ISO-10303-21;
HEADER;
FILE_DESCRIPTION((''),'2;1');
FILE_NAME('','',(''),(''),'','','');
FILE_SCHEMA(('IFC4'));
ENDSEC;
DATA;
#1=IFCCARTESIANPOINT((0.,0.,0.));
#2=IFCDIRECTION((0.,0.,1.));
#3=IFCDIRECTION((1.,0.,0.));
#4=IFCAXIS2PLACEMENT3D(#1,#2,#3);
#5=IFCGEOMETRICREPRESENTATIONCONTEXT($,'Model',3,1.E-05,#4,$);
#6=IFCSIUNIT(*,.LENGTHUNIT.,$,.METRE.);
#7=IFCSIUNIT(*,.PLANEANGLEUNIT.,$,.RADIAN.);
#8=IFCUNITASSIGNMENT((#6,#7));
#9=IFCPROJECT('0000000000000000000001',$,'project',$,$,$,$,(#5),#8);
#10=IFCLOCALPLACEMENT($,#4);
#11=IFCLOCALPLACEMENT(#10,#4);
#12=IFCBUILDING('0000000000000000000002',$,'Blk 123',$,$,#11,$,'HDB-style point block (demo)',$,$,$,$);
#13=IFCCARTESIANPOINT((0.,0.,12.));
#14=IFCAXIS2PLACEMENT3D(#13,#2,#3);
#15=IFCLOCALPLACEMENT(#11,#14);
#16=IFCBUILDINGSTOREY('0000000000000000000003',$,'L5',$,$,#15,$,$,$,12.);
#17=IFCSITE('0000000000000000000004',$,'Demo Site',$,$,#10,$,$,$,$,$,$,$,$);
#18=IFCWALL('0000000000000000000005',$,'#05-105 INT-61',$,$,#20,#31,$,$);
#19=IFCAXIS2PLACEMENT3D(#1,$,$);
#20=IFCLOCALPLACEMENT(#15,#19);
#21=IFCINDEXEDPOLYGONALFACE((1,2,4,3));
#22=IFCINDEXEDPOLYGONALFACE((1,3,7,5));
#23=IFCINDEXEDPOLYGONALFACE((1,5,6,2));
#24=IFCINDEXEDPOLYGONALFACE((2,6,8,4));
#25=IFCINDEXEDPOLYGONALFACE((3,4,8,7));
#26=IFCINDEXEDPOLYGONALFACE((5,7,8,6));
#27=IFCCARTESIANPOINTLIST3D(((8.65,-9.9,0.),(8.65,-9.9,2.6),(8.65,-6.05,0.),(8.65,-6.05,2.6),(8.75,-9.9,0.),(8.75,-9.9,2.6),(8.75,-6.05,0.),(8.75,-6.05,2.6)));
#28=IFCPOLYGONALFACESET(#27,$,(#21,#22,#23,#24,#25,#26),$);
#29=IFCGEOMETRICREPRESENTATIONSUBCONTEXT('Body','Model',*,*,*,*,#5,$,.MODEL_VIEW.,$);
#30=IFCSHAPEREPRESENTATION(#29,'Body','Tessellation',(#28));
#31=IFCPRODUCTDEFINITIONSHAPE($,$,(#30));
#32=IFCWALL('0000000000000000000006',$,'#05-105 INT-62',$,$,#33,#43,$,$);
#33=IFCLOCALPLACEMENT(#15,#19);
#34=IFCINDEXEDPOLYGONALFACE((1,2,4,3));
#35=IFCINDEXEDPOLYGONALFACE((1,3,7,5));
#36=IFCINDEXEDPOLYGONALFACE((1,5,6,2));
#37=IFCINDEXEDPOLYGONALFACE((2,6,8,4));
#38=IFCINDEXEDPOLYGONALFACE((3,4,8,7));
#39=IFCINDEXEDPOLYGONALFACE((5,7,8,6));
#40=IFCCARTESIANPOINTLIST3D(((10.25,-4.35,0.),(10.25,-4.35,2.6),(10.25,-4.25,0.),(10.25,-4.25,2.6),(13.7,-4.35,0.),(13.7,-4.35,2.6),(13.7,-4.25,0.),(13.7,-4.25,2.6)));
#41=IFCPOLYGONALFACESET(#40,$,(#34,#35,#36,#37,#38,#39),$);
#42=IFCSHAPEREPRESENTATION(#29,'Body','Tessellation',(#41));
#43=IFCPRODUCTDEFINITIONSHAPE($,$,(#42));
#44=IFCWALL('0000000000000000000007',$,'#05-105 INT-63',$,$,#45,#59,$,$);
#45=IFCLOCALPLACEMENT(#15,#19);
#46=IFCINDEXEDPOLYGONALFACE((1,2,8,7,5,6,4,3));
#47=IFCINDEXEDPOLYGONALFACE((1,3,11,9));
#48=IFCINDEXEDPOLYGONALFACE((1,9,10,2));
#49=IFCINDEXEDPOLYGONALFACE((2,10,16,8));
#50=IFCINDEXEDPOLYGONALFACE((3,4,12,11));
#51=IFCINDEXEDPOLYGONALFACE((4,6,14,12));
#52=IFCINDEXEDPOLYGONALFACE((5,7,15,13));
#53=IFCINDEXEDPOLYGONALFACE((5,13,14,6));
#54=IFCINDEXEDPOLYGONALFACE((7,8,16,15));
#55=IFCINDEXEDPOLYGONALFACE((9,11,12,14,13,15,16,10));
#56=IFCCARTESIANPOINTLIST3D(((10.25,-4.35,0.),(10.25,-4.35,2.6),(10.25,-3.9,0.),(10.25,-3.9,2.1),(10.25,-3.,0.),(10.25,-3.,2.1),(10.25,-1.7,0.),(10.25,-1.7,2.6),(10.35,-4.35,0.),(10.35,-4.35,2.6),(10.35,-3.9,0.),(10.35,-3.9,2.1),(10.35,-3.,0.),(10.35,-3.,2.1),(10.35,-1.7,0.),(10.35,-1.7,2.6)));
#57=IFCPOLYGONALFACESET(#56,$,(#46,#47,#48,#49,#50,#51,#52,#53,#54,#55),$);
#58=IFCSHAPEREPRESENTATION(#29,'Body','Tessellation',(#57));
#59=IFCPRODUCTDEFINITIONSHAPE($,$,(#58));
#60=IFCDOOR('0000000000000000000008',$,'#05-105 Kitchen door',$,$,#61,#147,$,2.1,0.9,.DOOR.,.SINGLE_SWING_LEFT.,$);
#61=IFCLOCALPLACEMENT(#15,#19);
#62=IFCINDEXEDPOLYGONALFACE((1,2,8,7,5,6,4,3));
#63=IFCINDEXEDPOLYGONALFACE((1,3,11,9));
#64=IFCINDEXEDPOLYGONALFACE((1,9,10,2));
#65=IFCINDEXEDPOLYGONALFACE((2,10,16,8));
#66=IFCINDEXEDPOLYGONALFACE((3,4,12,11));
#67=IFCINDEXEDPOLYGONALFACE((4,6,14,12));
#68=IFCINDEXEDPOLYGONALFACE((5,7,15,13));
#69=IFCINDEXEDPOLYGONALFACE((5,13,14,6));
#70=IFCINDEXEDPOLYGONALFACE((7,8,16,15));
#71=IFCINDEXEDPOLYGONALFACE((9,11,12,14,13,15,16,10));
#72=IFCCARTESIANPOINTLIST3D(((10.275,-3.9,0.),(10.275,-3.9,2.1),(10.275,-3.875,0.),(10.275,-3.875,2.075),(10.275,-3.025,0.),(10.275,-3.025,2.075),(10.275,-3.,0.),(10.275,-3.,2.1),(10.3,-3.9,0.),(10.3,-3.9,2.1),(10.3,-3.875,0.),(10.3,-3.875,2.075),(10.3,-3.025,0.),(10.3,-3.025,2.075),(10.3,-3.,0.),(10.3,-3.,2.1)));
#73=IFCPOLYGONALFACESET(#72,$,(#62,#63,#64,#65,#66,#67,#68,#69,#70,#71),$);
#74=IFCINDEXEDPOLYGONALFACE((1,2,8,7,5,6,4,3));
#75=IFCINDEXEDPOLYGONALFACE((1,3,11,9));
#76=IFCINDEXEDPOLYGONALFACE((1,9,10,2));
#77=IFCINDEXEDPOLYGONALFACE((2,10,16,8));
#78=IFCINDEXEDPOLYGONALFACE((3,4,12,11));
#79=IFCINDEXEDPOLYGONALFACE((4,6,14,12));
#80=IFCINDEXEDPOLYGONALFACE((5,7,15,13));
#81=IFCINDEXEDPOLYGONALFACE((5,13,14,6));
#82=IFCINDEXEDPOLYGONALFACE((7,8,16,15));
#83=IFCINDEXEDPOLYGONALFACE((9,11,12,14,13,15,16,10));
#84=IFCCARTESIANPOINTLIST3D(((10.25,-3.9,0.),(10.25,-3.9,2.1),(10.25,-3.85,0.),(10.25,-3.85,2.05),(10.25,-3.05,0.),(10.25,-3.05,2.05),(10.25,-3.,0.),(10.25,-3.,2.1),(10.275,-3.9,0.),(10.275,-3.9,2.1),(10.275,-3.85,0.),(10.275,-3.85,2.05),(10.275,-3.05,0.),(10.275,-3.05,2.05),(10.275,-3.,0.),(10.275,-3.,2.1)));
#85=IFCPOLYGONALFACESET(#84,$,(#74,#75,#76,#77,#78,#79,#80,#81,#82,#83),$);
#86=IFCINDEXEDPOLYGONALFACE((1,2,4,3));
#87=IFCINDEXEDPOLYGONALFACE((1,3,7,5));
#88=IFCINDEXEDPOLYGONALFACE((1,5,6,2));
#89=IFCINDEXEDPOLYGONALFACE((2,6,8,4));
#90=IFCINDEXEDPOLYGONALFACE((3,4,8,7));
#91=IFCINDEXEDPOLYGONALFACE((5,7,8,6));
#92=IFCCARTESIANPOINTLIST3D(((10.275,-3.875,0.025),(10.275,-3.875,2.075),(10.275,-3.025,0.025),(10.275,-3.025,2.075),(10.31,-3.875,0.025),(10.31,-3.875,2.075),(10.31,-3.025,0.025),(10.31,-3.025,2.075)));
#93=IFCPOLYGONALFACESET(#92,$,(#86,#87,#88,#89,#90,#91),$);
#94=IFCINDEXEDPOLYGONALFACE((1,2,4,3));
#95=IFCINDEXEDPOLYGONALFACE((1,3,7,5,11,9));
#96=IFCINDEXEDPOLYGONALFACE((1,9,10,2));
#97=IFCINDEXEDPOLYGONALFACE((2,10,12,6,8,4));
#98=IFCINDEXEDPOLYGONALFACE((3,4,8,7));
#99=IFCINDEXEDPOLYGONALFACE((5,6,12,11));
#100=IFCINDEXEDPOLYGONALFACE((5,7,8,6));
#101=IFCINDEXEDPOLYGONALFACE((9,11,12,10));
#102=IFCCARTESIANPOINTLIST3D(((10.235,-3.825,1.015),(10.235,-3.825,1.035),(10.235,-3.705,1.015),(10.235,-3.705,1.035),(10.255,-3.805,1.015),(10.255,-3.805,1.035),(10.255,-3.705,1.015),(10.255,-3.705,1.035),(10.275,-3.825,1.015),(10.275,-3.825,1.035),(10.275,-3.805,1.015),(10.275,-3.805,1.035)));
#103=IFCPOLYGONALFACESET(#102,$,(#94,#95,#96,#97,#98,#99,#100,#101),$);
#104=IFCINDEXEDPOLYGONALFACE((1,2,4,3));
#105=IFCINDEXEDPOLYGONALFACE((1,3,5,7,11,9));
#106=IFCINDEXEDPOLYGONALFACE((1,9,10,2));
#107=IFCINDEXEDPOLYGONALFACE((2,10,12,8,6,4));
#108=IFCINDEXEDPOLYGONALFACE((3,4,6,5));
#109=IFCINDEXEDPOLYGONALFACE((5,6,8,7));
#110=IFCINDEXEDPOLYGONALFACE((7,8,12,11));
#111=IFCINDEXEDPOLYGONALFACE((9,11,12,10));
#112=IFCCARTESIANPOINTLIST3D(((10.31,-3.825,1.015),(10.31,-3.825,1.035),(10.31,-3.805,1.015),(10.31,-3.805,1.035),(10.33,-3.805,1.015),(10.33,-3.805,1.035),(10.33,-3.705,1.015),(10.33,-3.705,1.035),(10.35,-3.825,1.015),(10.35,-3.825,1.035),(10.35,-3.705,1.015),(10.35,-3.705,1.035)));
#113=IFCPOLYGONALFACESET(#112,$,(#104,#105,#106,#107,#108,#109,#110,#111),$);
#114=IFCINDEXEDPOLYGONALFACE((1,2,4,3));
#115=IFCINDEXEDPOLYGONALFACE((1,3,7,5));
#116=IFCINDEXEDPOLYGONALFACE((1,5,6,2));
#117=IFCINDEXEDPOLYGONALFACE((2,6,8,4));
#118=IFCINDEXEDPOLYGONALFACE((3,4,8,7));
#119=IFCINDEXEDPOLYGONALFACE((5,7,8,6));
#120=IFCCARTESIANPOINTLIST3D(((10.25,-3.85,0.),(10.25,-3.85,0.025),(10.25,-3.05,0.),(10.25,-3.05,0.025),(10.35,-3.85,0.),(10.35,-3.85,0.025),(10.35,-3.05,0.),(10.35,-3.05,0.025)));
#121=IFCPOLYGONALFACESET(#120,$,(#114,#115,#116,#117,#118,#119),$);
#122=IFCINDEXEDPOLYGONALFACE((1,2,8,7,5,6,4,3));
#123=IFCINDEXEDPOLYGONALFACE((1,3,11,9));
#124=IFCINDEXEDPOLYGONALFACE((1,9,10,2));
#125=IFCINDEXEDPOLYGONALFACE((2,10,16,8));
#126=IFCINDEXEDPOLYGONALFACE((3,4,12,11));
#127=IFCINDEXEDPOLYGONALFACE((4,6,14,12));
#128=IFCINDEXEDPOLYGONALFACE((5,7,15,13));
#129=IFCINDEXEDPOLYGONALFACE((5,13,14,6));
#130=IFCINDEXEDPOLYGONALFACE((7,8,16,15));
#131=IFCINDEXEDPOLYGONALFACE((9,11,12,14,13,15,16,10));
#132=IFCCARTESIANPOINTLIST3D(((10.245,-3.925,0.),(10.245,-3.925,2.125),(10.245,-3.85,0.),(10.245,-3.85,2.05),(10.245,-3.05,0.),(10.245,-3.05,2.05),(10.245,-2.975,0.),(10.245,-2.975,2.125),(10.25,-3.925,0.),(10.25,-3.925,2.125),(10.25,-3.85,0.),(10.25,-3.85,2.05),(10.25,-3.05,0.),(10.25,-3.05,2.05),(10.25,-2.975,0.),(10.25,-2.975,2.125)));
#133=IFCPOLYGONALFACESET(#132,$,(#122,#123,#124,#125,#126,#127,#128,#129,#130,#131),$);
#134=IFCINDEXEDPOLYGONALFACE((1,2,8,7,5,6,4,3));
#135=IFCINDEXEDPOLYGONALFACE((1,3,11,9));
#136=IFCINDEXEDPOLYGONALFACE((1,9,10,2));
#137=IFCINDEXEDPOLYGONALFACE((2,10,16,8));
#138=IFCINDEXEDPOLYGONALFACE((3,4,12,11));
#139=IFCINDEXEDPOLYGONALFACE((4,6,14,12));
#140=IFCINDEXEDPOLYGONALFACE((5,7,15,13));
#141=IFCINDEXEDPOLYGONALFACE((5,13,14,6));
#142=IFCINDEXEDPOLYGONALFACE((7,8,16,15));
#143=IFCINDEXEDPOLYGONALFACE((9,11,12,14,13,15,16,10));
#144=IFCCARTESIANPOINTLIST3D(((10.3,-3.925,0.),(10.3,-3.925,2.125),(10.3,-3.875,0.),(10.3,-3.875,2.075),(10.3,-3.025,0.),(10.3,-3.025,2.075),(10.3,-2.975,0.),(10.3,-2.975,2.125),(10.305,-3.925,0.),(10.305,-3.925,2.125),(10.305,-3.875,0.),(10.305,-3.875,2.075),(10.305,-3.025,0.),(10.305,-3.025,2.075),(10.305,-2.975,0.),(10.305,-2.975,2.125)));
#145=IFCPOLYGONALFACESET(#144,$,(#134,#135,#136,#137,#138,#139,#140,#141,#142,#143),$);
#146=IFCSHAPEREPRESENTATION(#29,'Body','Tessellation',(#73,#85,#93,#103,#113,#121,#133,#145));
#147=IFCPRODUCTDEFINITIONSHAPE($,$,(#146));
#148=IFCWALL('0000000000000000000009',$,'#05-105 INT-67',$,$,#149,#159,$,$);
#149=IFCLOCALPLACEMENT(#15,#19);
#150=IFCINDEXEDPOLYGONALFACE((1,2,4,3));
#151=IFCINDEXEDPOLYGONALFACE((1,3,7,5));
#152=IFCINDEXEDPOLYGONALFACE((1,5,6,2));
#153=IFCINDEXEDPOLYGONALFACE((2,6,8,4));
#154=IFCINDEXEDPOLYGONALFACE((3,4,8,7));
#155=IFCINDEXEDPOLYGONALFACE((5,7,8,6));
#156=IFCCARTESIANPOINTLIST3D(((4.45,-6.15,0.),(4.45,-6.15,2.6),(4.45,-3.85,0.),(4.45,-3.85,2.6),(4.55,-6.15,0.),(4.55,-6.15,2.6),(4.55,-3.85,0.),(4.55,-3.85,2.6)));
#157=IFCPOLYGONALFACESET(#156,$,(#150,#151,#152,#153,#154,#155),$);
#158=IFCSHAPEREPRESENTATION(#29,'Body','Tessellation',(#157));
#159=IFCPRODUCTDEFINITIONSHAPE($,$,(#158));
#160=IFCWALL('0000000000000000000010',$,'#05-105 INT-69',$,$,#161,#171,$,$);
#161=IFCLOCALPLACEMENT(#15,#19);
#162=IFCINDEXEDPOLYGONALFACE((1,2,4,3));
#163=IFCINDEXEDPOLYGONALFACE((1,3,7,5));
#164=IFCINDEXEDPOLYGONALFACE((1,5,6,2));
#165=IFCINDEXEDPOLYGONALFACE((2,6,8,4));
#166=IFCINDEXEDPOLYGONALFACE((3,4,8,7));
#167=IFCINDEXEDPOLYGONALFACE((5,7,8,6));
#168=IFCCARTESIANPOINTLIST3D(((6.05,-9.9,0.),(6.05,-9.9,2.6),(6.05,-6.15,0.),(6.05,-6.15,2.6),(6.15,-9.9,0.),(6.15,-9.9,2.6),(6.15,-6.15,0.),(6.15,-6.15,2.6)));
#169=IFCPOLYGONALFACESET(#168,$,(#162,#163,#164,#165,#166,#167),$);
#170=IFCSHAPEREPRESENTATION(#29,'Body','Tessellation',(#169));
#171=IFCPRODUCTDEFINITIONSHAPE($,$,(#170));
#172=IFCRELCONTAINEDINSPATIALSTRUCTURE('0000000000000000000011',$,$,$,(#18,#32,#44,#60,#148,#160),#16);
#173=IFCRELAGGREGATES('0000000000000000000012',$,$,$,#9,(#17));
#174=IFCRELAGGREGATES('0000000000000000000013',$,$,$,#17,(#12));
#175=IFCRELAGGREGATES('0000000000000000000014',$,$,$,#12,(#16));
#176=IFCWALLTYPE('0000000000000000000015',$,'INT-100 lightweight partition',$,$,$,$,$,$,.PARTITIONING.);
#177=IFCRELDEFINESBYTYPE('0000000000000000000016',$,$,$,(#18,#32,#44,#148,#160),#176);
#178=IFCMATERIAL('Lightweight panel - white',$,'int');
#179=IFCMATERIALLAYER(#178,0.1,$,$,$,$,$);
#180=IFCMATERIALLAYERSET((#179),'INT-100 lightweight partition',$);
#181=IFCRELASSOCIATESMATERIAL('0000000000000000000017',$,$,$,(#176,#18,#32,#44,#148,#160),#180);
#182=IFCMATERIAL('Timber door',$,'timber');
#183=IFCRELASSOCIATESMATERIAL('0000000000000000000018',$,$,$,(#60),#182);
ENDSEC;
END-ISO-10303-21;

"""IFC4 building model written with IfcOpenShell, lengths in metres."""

from ifc_helpers import new_model, si_unit, frame, origin_with_axes, place, context, subcontext, project, spatial, line, indexed_curve, outline, extrude, material, layer, layer_set, layer_usage, type_object, element, fill, save


model = new_model("IFC4")

# Units and contexts
model_context = context("Model", 3, precision=1e-05, world=origin_with_axes())
body_context = subcontext(model_context, "Body", "Model", "MODEL_VIEW")
ifc_project = project(units=[si_unit("LENGTHUNIT", "METRE"), si_unit("PLANEANGLEUNIT", "RADIAN")], contexts=[model_context])

# Site, building, storey
site_placement = place(None, origin_with_axes())
site = spatial("IfcSite", under=ifc_project, at=site_placement, Name="Demo Site")
building_placement = place(site_placement, origin_with_axes())
building = spatial("IfcBuilding", under=site, at=building_placement, Name="Blk 123", LongName="HDB-style point block (demo)")
storey_placement = place(building_placement, frame((0.0, 0.0, 12.0), z_axis=(0.0, 0.0, 1.0), x_axis=(1.0, 0.0, 0.0)))
storey = spatial("IfcBuildingStorey", under=building, at=storey_placement, Name="L5", Elevation=12.0)

# Walls
ifc_material_1 = material(Name="Lightweight panel - white", Category="int")
ifc_layer_1 = layer(ifc_material_1, 0.1)
ifc_layer_set_1 = layer_set([ifc_layer_1], Name="INT-100 lightweight partition")
ifc_layer_usage_1 = layer_usage(ifc_layer_set_1, "AXIS2", "POSITIVE", -0.05)
wall_type_1 = type_object("IfcWallType", Name="INT-100 lightweight partition", PredefinedType="PARTITIONING", material=ifc_layer_set_1)
wall_1_placement = place(storey_placement, frame((8.7, -6.05, 0.0), z_axis=(0.0, 0.0, 1.0), x_axis=(0.0, -1.0, 0.0)))
element("IfcWall", 1, at=wall_1_placement, inside=storey, type_object=wall_type_1, material=ifc_layer_usage_1, Name="#05-105 INT-61", context=body_context, shape_type="SweptSolid", body=[
    extrude(outline(indexed_curve([(0.0, 0.0), (0.0, 0.1), (3.85, 0.1), (3.85, 0.0), (0.0, 0.0)], self_intersect=False)), frame((0.0, -0.05, 0.0), z_axis=(0.0, 0.0, 1.0), x_axis=(1.0, 0.0, 0.0)), (0.0, 0.0, 1.0), 2.6),
])
wall_2_placement = place(storey_placement, frame((10.25, -4.3, 0.0), z_axis=(0.0, 0.0, 1.0), x_axis=(1.0, 0.0, 0.0)))
element("IfcWall", 2, at=wall_2_placement, inside=storey, type_object=wall_type_1, material=ifc_layer_usage_1, Name="#05-105 INT-62", context=body_context, shape_type="SweptSolid", body=[
    extrude(outline(indexed_curve([(0.0, 0.0), (0.0, 0.1), (3.45, 0.1), (3.45, 0.0), (0.0, 0.0)], self_intersect=False)), frame((0.0, -0.05, 0.0), z_axis=(0.0, 0.0, 1.0), x_axis=(1.0, 0.0, 0.0)), (0.0, 0.0, 1.0), 2.6),
])

# Wall, opening, door
wall_3_placement = place(storey_placement, frame((10.3, -1.7, 0.0), z_axis=(0.0, 0.0, 1.0), x_axis=(0.0, -1.0, 0.0)))
wall_3 = element("IfcWall", 3, at=wall_3_placement, inside=storey, type_object=wall_type_1, material=ifc_layer_usage_1, Name="#05-105 INT-63", context=body_context, shape_type="SweptSolid", body=[
    extrude(outline(indexed_curve([(0.0, 0.0), (0.0, 0.1), (2.65, 0.1), (2.65, 0.0), (0.0, 0.0)], self_intersect=False)), frame((0.0, -0.05, 0.0), z_axis=(0.0, 0.0, 1.0), x_axis=(1.0, 0.0, 0.0)), (0.0, 0.0, 1.0), 2.6),
])
opening_1_placement = place(wall_3_placement, frame((1.3, -0.15, 0.0), z_axis=(0.0, 0.0, 1.0), x_axis=(1.0, 0.0, 0.0)))
opening_1 = element("IfcOpeningElement", 4, at=opening_1_placement, cuts=wall_3, context=body_context, shape_type="SweptSolid", body=[
    extrude(outline(indexed_curve([(0.0, 0.0), (0.0, 0.3), (0.9, 0.3), (0.9, 0.0), (0.0, 0.0)], self_intersect=False)), origin_with_axes(), (0.0, 0.0, 1.0), 2.1),
])
ifc_material_2 = material(Name="Timber door", Category="timber")
door_1_placement = place(opening_1_placement, frame((0.0, 0.1, 0.0), z_axis=(0.0, 0.0, 1.0), x_axis=(1.0, 0.0, 0.0)))
door_1 = element("IfcDoor", 5, at=door_1_placement, inside=storey, material=ifc_material_2, Name="#05-105 Kitchen door", OperationType="SINGLE_SWING_LEFT", OverallHeight=2.1, OverallWidth=0.9, PredefinedType="DOOR", context=body_context, shape_type="SweptSolid", body=[
    extrude(outline(indexed_curve([(0.0, 0.0), (0.0, 2.1), (0.9, 2.1), (0.9, 0.0), (0.875, 0.0), (0.875, 2.075), (0.025, 2.075), (0.025, 0.0)], segments=[line(1, 2, 3, 4, 5, 6, 7, 8, 1)])), frame((0.0, 0.025, 0.0), z_axis=(0.0, -1.0, 0.0), x_axis=(1.0, 0.0, 0.0)), (0.0, 0.0, -1.0), 0.025),
    extrude(outline(indexed_curve([(0.0, 0.0), (0.0, 2.1), (0.9, 2.1), (0.9, 0.0), (0.85, 0.0), (0.85, 2.05), (0.05, 2.05), (0.05, 0.0)], segments=[line(1, 2, 3, 4, 5, 6, 7, 8, 1)])), frame((0.0, 0.0, 0.0), z_axis=(0.0, -1.0, 0.0), x_axis=(1.0, 0.0, 0.0)), (0.0, 0.0, -1.0), 0.025),
    extrude(outline(indexed_curve([(0.0, 0.0), (0.85, 0.0), (0.85, 0.035), (0.0, 0.035)], segments=[line(1, 2, 3, 4, 1)])), frame((0.025, 0.025, 0.025), z_axis=(0.0, 0.0, 1.0), x_axis=(1.0, 0.0, 0.0)), (0.0, 0.0, 1.0), 2.05),
    extrude(outline(indexed_curve([(0.0, 0.0), (0.0, -0.04), (-0.12, -0.04), (-0.12, -0.02), (-0.02, -0.02), (-0.02, 0.0)], segments=[line(1, 2, 3, 4, 5, 6, 1)])), frame((0.825, 0.025, 1.015), z_axis=(0.0, 0.0, 1.0), x_axis=(1.0, 0.0, 0.0)), (0.0, 0.0, 1.0), 0.02),
    extrude(outline(indexed_curve([(0.0, 0.0), (0.0, 0.04), (-0.12, 0.04), (-0.12, 0.02), (-0.02, 0.02), (-0.02, 0.0)], segments=[line(1, 2, 3, 4, 5, 6, 1)])), frame((0.825, 0.06, 1.015), z_axis=(0.0, 0.0, 1.0), x_axis=(1.0, 0.0, 0.0)), (0.0, 0.0, 1.0), 0.02),
    extrude(outline(indexed_curve([(0.0, 0.0), (0.8, 0.0), (0.8, 0.1), (0.0, 0.1)], segments=[line(1, 2, 3, 4, 1)])), frame((0.05, 0.0, 0.0), z_axis=(0.0, 0.0, 1.0), x_axis=(1.0, 0.0, 0.0)), (0.0, 0.0, 1.0), 0.025),
    extrude(outline(indexed_curve([(0.0, 0.0), (0.0, 2.125), (0.95, 2.125), (0.95, 0.0), (0.875, 0.0), (0.875, 2.05), (0.075, 2.05), (0.075, 0.0)], segments=[line(1, 2, 3, 4, 5, 6, 7, 8, 1)])), frame((-0.025, -0.005, 0.0), z_axis=(0.0, -1.0, 0.0), x_axis=(1.0, 0.0, 0.0)), (0.0, 0.0, -1.0), 0.005),
    extrude(outline(indexed_curve([(0.0, 0.0), (0.0, 2.125), (0.95, 2.125), (0.95, 0.0), (0.9, 0.0), (0.9, 2.075), (0.05, 2.075), (0.05, 0.0)], segments=[line(1, 2, 3, 4, 5, 6, 7, 8, 1)])), frame((-0.025, 0.05, 0.0), z_axis=(0.0, -1.0, 0.0), x_axis=(1.0, 0.0, 0.0)), (0.0, 0.0, -1.0), 0.005),
])
fill(opening_1, door_1)

# Walls
wall_4_placement = place(storey_placement, frame((4.5, -3.85, 0.0), z_axis=(0.0, 0.0, 1.0), x_axis=(0.0, -1.0, 0.0)))
element("IfcWall", 6, at=wall_4_placement, inside=storey, type_object=wall_type_1, material=ifc_layer_usage_1, Name="#05-105 INT-67", context=body_context, shape_type="SweptSolid", body=[
    extrude(outline(indexed_curve([(0.0, 0.0), (0.0, 0.1), (2.3, 0.1), (2.3, 0.0), (0.0, 0.0)], self_intersect=False)), frame((0.0, -0.05, 0.0), z_axis=(0.0, 0.0, 1.0), x_axis=(1.0, 0.0, 0.0)), (0.0, 0.0, 1.0), 2.6),
])
wall_5_placement = place(storey_placement, frame((6.1, -6.15, 0.0), z_axis=(0.0, 0.0, 1.0), x_axis=(0.0, -1.0, 0.0)))
element("IfcWall", 7, at=wall_5_placement, inside=storey, type_object=wall_type_1, material=ifc_layer_usage_1, Name="#05-105 INT-69", context=body_context, shape_type="SweptSolid", body=[
    extrude(outline(indexed_curve([(0.0, 0.0), (0.0, 0.1), (3.75, 0.1), (3.75, 0.0), (0.0, 0.0)], self_intersect=False)), frame((0.0, -0.05, 0.0), z_axis=(0.0, 0.0, 1.0), x_axis=(1.0, 0.0, 0.0)), (0.0, 0.0, 1.0), 2.6),
])

save(model, "model.ifc")
